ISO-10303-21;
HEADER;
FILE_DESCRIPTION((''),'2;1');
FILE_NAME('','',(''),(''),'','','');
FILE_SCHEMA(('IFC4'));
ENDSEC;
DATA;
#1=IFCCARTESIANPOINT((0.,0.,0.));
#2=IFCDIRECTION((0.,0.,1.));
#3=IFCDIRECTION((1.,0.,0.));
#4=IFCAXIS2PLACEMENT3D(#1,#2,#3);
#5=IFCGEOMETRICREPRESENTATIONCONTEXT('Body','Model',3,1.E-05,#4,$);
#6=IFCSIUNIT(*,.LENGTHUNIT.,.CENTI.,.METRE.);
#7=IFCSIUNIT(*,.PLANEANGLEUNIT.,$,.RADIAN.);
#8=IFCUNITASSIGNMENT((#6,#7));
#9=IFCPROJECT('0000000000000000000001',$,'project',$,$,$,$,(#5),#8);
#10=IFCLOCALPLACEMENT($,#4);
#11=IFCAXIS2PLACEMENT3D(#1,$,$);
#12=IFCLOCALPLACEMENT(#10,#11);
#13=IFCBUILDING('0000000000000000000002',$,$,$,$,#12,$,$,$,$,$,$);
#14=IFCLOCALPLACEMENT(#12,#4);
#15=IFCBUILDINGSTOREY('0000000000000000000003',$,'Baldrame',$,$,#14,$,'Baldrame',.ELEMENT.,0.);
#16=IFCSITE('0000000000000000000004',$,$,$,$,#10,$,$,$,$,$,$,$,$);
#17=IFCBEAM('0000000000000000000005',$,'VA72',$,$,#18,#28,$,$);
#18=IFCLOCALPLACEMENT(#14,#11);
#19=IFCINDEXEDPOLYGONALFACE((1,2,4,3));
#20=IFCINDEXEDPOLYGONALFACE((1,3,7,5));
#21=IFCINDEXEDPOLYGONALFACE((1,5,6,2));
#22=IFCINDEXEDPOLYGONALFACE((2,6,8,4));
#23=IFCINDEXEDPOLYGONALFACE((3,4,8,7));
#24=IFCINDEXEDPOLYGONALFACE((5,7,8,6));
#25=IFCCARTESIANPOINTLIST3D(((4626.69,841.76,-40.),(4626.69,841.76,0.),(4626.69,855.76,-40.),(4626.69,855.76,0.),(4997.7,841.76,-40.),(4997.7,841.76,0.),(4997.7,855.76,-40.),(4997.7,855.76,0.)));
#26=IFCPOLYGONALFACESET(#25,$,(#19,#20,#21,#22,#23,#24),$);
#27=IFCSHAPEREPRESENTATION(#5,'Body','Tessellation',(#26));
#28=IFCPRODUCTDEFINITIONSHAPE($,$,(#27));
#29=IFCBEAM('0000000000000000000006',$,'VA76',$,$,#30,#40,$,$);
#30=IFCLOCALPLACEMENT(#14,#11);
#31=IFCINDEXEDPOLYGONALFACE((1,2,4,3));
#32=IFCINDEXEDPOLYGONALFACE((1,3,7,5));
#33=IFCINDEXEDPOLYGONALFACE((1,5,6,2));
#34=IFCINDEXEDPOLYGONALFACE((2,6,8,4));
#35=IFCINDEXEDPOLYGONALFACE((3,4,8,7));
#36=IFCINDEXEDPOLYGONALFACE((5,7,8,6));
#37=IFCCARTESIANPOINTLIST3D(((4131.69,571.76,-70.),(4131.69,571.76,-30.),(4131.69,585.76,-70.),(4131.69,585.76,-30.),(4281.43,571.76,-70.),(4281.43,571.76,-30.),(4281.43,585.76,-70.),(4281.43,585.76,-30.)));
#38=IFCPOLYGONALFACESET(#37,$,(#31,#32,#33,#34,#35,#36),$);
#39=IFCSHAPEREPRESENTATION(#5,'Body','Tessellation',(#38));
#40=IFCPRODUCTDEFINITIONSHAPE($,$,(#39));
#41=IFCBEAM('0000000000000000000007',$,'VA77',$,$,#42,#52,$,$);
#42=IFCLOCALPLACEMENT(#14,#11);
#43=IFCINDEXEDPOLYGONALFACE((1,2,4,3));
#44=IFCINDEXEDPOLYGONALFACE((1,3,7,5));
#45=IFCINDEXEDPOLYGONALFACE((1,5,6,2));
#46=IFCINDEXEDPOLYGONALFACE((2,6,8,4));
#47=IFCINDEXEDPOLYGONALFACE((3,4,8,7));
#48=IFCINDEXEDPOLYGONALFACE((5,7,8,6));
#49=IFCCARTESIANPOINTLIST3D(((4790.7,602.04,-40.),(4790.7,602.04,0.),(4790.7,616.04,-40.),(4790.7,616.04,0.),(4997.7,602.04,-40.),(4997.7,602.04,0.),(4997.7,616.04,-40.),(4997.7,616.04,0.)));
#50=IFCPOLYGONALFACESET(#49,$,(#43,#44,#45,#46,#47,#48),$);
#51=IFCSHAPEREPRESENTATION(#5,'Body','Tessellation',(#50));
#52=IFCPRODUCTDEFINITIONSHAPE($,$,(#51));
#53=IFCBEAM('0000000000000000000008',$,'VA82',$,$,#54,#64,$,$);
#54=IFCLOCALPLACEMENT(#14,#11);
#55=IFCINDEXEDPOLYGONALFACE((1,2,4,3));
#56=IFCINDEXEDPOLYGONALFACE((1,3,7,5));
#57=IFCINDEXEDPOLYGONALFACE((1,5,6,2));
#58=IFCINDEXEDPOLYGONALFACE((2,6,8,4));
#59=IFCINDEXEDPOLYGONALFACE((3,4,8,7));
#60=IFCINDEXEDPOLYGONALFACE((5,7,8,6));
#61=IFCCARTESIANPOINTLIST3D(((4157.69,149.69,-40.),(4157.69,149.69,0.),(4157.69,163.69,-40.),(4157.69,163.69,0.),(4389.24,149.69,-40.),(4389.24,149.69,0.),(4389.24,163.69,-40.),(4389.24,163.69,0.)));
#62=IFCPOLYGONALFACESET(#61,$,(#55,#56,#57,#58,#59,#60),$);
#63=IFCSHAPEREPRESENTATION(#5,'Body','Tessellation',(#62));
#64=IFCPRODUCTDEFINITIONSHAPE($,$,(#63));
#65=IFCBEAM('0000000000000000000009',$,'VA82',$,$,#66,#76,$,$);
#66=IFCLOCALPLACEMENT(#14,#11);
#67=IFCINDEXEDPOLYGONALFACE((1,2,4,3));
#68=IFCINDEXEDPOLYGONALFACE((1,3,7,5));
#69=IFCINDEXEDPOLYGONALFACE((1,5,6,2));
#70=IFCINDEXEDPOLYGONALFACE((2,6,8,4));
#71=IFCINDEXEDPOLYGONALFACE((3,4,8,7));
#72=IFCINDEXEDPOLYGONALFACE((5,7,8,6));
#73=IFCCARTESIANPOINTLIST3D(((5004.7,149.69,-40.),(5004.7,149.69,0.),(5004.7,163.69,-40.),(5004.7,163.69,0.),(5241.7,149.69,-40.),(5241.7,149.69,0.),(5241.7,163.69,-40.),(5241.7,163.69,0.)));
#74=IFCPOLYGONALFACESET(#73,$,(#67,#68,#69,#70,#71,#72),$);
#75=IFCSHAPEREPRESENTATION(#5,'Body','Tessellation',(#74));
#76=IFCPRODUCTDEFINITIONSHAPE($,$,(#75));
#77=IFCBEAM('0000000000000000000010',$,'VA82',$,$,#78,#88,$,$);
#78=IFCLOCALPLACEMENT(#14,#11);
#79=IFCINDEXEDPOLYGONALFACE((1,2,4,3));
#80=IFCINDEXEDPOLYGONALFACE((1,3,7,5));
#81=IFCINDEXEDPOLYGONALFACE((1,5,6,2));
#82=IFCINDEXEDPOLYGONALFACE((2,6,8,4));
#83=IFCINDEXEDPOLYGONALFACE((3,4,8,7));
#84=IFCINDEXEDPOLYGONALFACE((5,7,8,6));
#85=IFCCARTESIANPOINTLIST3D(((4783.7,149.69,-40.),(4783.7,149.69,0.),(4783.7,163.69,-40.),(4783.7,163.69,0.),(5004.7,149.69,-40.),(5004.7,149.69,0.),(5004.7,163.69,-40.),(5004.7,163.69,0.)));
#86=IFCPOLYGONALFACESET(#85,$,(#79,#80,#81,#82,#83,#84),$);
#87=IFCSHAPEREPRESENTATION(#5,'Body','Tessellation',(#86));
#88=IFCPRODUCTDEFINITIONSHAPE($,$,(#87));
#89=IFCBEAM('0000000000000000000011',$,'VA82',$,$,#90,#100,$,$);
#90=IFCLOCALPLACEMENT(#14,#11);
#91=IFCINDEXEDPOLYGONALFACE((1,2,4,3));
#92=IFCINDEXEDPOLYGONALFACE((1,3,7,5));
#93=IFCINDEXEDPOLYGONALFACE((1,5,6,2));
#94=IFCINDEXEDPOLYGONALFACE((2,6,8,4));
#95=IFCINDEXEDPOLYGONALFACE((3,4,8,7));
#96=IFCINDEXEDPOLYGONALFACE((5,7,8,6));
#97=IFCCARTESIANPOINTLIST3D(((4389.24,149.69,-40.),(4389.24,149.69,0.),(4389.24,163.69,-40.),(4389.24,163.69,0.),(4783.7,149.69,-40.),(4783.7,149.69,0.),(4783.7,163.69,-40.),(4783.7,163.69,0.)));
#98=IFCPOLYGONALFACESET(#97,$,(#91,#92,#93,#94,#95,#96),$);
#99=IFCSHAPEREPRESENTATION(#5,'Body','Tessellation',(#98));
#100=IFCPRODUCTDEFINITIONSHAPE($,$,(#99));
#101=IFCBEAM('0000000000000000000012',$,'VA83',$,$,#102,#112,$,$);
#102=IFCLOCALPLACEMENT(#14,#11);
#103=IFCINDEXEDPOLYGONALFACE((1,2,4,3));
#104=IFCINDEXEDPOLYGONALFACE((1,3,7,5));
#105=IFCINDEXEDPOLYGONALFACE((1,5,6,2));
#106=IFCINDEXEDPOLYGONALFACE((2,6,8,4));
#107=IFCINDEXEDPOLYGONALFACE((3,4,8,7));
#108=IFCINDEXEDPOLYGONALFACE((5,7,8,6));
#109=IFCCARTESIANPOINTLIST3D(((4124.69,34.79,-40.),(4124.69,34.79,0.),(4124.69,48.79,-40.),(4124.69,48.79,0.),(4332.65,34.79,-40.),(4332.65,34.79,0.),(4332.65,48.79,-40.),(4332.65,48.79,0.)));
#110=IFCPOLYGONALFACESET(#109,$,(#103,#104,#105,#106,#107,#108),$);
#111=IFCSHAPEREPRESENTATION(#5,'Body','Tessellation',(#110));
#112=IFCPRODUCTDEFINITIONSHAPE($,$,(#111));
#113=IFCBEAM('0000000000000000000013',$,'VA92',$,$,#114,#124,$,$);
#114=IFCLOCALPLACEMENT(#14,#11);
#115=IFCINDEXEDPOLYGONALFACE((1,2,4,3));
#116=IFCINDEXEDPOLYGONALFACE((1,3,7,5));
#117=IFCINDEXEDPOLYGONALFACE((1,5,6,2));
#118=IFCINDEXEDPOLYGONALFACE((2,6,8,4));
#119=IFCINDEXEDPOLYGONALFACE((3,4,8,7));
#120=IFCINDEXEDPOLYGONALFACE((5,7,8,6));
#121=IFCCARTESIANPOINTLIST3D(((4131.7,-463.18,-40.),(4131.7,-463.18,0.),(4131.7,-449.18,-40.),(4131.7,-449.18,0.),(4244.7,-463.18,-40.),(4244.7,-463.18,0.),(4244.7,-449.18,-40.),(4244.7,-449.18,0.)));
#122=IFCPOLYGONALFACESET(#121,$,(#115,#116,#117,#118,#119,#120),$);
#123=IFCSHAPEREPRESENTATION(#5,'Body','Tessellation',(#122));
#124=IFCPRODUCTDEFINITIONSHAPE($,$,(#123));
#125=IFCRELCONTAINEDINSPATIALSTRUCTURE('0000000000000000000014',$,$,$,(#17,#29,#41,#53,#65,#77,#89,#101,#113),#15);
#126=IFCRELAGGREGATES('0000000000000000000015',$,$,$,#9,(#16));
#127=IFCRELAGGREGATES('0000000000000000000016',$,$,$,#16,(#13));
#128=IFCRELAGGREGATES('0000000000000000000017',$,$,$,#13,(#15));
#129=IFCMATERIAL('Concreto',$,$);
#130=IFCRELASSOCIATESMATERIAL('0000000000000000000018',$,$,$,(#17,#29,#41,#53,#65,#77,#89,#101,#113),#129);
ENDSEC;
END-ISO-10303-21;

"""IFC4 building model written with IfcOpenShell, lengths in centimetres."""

from ifc_helpers import new_model, si_unit, frame, origin, origin_with_axes, origin_2d_with_axis, place, context, project, spatial, rectangle, extrude, material, element, save


model = new_model("IFC4")

# Units and contexts
model_context = context("Model", 3, precision=1e-05, world=origin_with_axes(), identifier="Body")
ifc_project = project(units=[si_unit("LENGTHUNIT", "METRE", prefix="CENTI"), si_unit("PLANEANGLEUNIT", "RADIAN")], contexts=[model_context])

# Site, building, storey
site_placement = place(None, origin_with_axes())
site = spatial("IfcSite", under=ifc_project, at=site_placement)
building_placement = place(site_placement, origin())
building = spatial("IfcBuilding", under=site, at=building_placement)
storey_placement = place(building_placement, origin_with_axes())
storey = spatial("IfcBuildingStorey", under=building, at=storey_placement, Name="Baldrame", LongName="Baldrame", CompositionType="ELEMENT", Elevation=0.0)

# Shared definitions
ifc_material = material(Name="Concreto")

# Beams
beam_1_placement = place(storey_placement, frame((4812.19, 848.76, 0.0), z_axis=(0.0, 0.0, 1.0), x_axis=(1.0, 0.0, 0.0)))
element("IfcBeam", 1, at=beam_1_placement, inside=storey, material=ifc_material, Name="VA72", context=model_context, shape_type="SolidModel", body=[
    extrude(rectangle(XDim=14.0, YDim=40.0, at=origin_2d_with_axis()), frame((-185.5, 0.0, -20.0), z_axis=(1.0, 0.0, 0.0), x_axis=(0.0, 1.0, 0.0)), (0.0, 0.0, 1.0), 371.01),
])
beam_2_placement = place(storey_placement, frame((4206.56, 578.76, -30.0), z_axis=(0.0, 0.0, 1.0), x_axis=(1.0, 0.0, 0.0)))
element("IfcBeam", 2, at=beam_2_placement, inside=storey, material=ifc_material, Name="VA76", context=model_context, shape_type="SolidModel", body=[
    extrude(rectangle(XDim=14.0, YDim=40.0, at=origin_2d_with_axis()), frame((-74.87, 0.0, -20.0), z_axis=(1.0, 0.0, 0.0), x_axis=(0.0, 1.0, 0.0)), (0.0, 0.0, 1.0), 149.74),
])
beam_3_placement = place(storey_placement, frame((4894.2, 609.04, 0.0), z_axis=(0.0, 0.0, 1.0), x_axis=(1.0, 0.0, 0.0)))
element("IfcBeam", 3, at=beam_3_placement, inside=storey, material=ifc_material, Name="VA77", context=model_context, shape_type="SolidModel", body=[
    extrude(rectangle(XDim=14.0, YDim=40.0, at=origin_2d_with_axis()), frame((-103.5, 0.0, -20.0), z_axis=(1.0, 0.0, 0.0), x_axis=(0.0, 1.0, 0.0)), (0.0, 0.0, 1.0), 207.0),
])
beam_4_placement = place(storey_placement, frame((4273.47, 156.69, 0.0), z_axis=(0.0, 0.0, 1.0), x_axis=(1.0, 0.0, 0.0)))
element("IfcBeam", 4, at=beam_4_placement, inside=storey, material=ifc_material, Name="VA82", context=model_context, shape_type="SolidModel", body=[
    extrude(rectangle(XDim=14.0, YDim=40.0, at=origin_2d_with_axis()), frame((-115.78, 0.0, -20.0), z_axis=(1.0, 0.0, 0.0), x_axis=(0.0, 1.0, 0.0)), (0.0, 0.0, 1.0), 231.55),
])
beam_5_placement = place(storey_placement, frame((5123.2, 156.69, 0.0), z_axis=(0.0, 0.0, 1.0), x_axis=(1.0, 0.0, 0.0)))
element("IfcBeam", 5, at=beam_5_placement, inside=storey, material=ifc_material, Name="VA82", context=model_context, shape_type="SolidModel", body=[
    extrude(rectangle(XDim=14.0, YDim=40.0, at=origin_2d_with_axis()), frame((-118.5, 0.0, -20.0), z_axis=(1.0, 0.0, 0.0), x_axis=(0.0, 1.0, 0.0)), (0.0, 0.0, 1.0), 237.0),
])
beam_6_placement = place(storey_placement, frame((4894.2, 156.69, 0.0), z_axis=(0.0, 0.0, 1.0), x_axis=(1.0, 0.0, 0.0)))
element("IfcBeam", 6, at=beam_6_placement, inside=storey, material=ifc_material, Name="VA82", context=model_context, shape_type="SolidModel", body=[
    extrude(rectangle(XDim=14.0, YDim=40.0, at=origin_2d_with_axis()), frame((-110.5, 0.0, -20.0), z_axis=(1.0, 0.0, 0.0), x_axis=(0.0, 1.0, 0.0)), (0.0, 0.0, 1.0), 221.0),
])
beam_7_placement = place(storey_placement, frame((4586.47, 156.69, 0.0), z_axis=(0.0, 0.0, 1.0), x_axis=(1.0, 0.0, 0.0)))
element("IfcBeam", 7, at=beam_7_placement, inside=storey, material=ifc_material, Name="VA82", context=model_context, shape_type="SolidModel", body=[
    extrude(rectangle(XDim=14.0, YDim=40.0, at=origin_2d_with_axis()), frame((-197.23, 0.0, -20.0), z_axis=(1.0, 0.0, 0.0), x_axis=(0.0, 1.0, 0.0)), (0.0, 0.0, 1.0), 394.46),
])
beam_8_placement = place(storey_placement, frame((4228.67, 41.79, 0.0), z_axis=(0.0, 0.0, 1.0), x_axis=(1.0, 0.0, 0.0)))
element("IfcBeam", 8, at=beam_8_placement, inside=storey, material=ifc_material, Name="VA83", context=model_context, shape_type="SolidModel", body=[
    extrude(rectangle(XDim=14.0, YDim=40.0, at=origin_2d_with_axis()), frame((-103.98, 0.0, -20.0), z_axis=(1.0, 0.0, 0.0), x_axis=(0.0, 1.0, 0.0)), (0.0, 0.0, 1.0), 207.96),
])
beam_9_placement = place(storey_placement, frame((4188.2, -456.18, 0.0), z_axis=(0.0, 0.0, 1.0), x_axis=(1.0, 0.0, 0.0)))
element("IfcBeam", 9, at=beam_9_placement, inside=storey, material=ifc_material, Name="VA92", context=model_context, shape_type="SolidModel", body=[
    extrude(rectangle(XDim=14.0, YDim=40.0, at=origin_2d_with_axis()), frame((-56.5, 0.0, -20.0), z_axis=(1.0, 0.0, 0.0), x_axis=(0.0, 1.0, 0.0)), (0.0, 0.0, 1.0), 113.0),
])

save(model, "model.ifc")
